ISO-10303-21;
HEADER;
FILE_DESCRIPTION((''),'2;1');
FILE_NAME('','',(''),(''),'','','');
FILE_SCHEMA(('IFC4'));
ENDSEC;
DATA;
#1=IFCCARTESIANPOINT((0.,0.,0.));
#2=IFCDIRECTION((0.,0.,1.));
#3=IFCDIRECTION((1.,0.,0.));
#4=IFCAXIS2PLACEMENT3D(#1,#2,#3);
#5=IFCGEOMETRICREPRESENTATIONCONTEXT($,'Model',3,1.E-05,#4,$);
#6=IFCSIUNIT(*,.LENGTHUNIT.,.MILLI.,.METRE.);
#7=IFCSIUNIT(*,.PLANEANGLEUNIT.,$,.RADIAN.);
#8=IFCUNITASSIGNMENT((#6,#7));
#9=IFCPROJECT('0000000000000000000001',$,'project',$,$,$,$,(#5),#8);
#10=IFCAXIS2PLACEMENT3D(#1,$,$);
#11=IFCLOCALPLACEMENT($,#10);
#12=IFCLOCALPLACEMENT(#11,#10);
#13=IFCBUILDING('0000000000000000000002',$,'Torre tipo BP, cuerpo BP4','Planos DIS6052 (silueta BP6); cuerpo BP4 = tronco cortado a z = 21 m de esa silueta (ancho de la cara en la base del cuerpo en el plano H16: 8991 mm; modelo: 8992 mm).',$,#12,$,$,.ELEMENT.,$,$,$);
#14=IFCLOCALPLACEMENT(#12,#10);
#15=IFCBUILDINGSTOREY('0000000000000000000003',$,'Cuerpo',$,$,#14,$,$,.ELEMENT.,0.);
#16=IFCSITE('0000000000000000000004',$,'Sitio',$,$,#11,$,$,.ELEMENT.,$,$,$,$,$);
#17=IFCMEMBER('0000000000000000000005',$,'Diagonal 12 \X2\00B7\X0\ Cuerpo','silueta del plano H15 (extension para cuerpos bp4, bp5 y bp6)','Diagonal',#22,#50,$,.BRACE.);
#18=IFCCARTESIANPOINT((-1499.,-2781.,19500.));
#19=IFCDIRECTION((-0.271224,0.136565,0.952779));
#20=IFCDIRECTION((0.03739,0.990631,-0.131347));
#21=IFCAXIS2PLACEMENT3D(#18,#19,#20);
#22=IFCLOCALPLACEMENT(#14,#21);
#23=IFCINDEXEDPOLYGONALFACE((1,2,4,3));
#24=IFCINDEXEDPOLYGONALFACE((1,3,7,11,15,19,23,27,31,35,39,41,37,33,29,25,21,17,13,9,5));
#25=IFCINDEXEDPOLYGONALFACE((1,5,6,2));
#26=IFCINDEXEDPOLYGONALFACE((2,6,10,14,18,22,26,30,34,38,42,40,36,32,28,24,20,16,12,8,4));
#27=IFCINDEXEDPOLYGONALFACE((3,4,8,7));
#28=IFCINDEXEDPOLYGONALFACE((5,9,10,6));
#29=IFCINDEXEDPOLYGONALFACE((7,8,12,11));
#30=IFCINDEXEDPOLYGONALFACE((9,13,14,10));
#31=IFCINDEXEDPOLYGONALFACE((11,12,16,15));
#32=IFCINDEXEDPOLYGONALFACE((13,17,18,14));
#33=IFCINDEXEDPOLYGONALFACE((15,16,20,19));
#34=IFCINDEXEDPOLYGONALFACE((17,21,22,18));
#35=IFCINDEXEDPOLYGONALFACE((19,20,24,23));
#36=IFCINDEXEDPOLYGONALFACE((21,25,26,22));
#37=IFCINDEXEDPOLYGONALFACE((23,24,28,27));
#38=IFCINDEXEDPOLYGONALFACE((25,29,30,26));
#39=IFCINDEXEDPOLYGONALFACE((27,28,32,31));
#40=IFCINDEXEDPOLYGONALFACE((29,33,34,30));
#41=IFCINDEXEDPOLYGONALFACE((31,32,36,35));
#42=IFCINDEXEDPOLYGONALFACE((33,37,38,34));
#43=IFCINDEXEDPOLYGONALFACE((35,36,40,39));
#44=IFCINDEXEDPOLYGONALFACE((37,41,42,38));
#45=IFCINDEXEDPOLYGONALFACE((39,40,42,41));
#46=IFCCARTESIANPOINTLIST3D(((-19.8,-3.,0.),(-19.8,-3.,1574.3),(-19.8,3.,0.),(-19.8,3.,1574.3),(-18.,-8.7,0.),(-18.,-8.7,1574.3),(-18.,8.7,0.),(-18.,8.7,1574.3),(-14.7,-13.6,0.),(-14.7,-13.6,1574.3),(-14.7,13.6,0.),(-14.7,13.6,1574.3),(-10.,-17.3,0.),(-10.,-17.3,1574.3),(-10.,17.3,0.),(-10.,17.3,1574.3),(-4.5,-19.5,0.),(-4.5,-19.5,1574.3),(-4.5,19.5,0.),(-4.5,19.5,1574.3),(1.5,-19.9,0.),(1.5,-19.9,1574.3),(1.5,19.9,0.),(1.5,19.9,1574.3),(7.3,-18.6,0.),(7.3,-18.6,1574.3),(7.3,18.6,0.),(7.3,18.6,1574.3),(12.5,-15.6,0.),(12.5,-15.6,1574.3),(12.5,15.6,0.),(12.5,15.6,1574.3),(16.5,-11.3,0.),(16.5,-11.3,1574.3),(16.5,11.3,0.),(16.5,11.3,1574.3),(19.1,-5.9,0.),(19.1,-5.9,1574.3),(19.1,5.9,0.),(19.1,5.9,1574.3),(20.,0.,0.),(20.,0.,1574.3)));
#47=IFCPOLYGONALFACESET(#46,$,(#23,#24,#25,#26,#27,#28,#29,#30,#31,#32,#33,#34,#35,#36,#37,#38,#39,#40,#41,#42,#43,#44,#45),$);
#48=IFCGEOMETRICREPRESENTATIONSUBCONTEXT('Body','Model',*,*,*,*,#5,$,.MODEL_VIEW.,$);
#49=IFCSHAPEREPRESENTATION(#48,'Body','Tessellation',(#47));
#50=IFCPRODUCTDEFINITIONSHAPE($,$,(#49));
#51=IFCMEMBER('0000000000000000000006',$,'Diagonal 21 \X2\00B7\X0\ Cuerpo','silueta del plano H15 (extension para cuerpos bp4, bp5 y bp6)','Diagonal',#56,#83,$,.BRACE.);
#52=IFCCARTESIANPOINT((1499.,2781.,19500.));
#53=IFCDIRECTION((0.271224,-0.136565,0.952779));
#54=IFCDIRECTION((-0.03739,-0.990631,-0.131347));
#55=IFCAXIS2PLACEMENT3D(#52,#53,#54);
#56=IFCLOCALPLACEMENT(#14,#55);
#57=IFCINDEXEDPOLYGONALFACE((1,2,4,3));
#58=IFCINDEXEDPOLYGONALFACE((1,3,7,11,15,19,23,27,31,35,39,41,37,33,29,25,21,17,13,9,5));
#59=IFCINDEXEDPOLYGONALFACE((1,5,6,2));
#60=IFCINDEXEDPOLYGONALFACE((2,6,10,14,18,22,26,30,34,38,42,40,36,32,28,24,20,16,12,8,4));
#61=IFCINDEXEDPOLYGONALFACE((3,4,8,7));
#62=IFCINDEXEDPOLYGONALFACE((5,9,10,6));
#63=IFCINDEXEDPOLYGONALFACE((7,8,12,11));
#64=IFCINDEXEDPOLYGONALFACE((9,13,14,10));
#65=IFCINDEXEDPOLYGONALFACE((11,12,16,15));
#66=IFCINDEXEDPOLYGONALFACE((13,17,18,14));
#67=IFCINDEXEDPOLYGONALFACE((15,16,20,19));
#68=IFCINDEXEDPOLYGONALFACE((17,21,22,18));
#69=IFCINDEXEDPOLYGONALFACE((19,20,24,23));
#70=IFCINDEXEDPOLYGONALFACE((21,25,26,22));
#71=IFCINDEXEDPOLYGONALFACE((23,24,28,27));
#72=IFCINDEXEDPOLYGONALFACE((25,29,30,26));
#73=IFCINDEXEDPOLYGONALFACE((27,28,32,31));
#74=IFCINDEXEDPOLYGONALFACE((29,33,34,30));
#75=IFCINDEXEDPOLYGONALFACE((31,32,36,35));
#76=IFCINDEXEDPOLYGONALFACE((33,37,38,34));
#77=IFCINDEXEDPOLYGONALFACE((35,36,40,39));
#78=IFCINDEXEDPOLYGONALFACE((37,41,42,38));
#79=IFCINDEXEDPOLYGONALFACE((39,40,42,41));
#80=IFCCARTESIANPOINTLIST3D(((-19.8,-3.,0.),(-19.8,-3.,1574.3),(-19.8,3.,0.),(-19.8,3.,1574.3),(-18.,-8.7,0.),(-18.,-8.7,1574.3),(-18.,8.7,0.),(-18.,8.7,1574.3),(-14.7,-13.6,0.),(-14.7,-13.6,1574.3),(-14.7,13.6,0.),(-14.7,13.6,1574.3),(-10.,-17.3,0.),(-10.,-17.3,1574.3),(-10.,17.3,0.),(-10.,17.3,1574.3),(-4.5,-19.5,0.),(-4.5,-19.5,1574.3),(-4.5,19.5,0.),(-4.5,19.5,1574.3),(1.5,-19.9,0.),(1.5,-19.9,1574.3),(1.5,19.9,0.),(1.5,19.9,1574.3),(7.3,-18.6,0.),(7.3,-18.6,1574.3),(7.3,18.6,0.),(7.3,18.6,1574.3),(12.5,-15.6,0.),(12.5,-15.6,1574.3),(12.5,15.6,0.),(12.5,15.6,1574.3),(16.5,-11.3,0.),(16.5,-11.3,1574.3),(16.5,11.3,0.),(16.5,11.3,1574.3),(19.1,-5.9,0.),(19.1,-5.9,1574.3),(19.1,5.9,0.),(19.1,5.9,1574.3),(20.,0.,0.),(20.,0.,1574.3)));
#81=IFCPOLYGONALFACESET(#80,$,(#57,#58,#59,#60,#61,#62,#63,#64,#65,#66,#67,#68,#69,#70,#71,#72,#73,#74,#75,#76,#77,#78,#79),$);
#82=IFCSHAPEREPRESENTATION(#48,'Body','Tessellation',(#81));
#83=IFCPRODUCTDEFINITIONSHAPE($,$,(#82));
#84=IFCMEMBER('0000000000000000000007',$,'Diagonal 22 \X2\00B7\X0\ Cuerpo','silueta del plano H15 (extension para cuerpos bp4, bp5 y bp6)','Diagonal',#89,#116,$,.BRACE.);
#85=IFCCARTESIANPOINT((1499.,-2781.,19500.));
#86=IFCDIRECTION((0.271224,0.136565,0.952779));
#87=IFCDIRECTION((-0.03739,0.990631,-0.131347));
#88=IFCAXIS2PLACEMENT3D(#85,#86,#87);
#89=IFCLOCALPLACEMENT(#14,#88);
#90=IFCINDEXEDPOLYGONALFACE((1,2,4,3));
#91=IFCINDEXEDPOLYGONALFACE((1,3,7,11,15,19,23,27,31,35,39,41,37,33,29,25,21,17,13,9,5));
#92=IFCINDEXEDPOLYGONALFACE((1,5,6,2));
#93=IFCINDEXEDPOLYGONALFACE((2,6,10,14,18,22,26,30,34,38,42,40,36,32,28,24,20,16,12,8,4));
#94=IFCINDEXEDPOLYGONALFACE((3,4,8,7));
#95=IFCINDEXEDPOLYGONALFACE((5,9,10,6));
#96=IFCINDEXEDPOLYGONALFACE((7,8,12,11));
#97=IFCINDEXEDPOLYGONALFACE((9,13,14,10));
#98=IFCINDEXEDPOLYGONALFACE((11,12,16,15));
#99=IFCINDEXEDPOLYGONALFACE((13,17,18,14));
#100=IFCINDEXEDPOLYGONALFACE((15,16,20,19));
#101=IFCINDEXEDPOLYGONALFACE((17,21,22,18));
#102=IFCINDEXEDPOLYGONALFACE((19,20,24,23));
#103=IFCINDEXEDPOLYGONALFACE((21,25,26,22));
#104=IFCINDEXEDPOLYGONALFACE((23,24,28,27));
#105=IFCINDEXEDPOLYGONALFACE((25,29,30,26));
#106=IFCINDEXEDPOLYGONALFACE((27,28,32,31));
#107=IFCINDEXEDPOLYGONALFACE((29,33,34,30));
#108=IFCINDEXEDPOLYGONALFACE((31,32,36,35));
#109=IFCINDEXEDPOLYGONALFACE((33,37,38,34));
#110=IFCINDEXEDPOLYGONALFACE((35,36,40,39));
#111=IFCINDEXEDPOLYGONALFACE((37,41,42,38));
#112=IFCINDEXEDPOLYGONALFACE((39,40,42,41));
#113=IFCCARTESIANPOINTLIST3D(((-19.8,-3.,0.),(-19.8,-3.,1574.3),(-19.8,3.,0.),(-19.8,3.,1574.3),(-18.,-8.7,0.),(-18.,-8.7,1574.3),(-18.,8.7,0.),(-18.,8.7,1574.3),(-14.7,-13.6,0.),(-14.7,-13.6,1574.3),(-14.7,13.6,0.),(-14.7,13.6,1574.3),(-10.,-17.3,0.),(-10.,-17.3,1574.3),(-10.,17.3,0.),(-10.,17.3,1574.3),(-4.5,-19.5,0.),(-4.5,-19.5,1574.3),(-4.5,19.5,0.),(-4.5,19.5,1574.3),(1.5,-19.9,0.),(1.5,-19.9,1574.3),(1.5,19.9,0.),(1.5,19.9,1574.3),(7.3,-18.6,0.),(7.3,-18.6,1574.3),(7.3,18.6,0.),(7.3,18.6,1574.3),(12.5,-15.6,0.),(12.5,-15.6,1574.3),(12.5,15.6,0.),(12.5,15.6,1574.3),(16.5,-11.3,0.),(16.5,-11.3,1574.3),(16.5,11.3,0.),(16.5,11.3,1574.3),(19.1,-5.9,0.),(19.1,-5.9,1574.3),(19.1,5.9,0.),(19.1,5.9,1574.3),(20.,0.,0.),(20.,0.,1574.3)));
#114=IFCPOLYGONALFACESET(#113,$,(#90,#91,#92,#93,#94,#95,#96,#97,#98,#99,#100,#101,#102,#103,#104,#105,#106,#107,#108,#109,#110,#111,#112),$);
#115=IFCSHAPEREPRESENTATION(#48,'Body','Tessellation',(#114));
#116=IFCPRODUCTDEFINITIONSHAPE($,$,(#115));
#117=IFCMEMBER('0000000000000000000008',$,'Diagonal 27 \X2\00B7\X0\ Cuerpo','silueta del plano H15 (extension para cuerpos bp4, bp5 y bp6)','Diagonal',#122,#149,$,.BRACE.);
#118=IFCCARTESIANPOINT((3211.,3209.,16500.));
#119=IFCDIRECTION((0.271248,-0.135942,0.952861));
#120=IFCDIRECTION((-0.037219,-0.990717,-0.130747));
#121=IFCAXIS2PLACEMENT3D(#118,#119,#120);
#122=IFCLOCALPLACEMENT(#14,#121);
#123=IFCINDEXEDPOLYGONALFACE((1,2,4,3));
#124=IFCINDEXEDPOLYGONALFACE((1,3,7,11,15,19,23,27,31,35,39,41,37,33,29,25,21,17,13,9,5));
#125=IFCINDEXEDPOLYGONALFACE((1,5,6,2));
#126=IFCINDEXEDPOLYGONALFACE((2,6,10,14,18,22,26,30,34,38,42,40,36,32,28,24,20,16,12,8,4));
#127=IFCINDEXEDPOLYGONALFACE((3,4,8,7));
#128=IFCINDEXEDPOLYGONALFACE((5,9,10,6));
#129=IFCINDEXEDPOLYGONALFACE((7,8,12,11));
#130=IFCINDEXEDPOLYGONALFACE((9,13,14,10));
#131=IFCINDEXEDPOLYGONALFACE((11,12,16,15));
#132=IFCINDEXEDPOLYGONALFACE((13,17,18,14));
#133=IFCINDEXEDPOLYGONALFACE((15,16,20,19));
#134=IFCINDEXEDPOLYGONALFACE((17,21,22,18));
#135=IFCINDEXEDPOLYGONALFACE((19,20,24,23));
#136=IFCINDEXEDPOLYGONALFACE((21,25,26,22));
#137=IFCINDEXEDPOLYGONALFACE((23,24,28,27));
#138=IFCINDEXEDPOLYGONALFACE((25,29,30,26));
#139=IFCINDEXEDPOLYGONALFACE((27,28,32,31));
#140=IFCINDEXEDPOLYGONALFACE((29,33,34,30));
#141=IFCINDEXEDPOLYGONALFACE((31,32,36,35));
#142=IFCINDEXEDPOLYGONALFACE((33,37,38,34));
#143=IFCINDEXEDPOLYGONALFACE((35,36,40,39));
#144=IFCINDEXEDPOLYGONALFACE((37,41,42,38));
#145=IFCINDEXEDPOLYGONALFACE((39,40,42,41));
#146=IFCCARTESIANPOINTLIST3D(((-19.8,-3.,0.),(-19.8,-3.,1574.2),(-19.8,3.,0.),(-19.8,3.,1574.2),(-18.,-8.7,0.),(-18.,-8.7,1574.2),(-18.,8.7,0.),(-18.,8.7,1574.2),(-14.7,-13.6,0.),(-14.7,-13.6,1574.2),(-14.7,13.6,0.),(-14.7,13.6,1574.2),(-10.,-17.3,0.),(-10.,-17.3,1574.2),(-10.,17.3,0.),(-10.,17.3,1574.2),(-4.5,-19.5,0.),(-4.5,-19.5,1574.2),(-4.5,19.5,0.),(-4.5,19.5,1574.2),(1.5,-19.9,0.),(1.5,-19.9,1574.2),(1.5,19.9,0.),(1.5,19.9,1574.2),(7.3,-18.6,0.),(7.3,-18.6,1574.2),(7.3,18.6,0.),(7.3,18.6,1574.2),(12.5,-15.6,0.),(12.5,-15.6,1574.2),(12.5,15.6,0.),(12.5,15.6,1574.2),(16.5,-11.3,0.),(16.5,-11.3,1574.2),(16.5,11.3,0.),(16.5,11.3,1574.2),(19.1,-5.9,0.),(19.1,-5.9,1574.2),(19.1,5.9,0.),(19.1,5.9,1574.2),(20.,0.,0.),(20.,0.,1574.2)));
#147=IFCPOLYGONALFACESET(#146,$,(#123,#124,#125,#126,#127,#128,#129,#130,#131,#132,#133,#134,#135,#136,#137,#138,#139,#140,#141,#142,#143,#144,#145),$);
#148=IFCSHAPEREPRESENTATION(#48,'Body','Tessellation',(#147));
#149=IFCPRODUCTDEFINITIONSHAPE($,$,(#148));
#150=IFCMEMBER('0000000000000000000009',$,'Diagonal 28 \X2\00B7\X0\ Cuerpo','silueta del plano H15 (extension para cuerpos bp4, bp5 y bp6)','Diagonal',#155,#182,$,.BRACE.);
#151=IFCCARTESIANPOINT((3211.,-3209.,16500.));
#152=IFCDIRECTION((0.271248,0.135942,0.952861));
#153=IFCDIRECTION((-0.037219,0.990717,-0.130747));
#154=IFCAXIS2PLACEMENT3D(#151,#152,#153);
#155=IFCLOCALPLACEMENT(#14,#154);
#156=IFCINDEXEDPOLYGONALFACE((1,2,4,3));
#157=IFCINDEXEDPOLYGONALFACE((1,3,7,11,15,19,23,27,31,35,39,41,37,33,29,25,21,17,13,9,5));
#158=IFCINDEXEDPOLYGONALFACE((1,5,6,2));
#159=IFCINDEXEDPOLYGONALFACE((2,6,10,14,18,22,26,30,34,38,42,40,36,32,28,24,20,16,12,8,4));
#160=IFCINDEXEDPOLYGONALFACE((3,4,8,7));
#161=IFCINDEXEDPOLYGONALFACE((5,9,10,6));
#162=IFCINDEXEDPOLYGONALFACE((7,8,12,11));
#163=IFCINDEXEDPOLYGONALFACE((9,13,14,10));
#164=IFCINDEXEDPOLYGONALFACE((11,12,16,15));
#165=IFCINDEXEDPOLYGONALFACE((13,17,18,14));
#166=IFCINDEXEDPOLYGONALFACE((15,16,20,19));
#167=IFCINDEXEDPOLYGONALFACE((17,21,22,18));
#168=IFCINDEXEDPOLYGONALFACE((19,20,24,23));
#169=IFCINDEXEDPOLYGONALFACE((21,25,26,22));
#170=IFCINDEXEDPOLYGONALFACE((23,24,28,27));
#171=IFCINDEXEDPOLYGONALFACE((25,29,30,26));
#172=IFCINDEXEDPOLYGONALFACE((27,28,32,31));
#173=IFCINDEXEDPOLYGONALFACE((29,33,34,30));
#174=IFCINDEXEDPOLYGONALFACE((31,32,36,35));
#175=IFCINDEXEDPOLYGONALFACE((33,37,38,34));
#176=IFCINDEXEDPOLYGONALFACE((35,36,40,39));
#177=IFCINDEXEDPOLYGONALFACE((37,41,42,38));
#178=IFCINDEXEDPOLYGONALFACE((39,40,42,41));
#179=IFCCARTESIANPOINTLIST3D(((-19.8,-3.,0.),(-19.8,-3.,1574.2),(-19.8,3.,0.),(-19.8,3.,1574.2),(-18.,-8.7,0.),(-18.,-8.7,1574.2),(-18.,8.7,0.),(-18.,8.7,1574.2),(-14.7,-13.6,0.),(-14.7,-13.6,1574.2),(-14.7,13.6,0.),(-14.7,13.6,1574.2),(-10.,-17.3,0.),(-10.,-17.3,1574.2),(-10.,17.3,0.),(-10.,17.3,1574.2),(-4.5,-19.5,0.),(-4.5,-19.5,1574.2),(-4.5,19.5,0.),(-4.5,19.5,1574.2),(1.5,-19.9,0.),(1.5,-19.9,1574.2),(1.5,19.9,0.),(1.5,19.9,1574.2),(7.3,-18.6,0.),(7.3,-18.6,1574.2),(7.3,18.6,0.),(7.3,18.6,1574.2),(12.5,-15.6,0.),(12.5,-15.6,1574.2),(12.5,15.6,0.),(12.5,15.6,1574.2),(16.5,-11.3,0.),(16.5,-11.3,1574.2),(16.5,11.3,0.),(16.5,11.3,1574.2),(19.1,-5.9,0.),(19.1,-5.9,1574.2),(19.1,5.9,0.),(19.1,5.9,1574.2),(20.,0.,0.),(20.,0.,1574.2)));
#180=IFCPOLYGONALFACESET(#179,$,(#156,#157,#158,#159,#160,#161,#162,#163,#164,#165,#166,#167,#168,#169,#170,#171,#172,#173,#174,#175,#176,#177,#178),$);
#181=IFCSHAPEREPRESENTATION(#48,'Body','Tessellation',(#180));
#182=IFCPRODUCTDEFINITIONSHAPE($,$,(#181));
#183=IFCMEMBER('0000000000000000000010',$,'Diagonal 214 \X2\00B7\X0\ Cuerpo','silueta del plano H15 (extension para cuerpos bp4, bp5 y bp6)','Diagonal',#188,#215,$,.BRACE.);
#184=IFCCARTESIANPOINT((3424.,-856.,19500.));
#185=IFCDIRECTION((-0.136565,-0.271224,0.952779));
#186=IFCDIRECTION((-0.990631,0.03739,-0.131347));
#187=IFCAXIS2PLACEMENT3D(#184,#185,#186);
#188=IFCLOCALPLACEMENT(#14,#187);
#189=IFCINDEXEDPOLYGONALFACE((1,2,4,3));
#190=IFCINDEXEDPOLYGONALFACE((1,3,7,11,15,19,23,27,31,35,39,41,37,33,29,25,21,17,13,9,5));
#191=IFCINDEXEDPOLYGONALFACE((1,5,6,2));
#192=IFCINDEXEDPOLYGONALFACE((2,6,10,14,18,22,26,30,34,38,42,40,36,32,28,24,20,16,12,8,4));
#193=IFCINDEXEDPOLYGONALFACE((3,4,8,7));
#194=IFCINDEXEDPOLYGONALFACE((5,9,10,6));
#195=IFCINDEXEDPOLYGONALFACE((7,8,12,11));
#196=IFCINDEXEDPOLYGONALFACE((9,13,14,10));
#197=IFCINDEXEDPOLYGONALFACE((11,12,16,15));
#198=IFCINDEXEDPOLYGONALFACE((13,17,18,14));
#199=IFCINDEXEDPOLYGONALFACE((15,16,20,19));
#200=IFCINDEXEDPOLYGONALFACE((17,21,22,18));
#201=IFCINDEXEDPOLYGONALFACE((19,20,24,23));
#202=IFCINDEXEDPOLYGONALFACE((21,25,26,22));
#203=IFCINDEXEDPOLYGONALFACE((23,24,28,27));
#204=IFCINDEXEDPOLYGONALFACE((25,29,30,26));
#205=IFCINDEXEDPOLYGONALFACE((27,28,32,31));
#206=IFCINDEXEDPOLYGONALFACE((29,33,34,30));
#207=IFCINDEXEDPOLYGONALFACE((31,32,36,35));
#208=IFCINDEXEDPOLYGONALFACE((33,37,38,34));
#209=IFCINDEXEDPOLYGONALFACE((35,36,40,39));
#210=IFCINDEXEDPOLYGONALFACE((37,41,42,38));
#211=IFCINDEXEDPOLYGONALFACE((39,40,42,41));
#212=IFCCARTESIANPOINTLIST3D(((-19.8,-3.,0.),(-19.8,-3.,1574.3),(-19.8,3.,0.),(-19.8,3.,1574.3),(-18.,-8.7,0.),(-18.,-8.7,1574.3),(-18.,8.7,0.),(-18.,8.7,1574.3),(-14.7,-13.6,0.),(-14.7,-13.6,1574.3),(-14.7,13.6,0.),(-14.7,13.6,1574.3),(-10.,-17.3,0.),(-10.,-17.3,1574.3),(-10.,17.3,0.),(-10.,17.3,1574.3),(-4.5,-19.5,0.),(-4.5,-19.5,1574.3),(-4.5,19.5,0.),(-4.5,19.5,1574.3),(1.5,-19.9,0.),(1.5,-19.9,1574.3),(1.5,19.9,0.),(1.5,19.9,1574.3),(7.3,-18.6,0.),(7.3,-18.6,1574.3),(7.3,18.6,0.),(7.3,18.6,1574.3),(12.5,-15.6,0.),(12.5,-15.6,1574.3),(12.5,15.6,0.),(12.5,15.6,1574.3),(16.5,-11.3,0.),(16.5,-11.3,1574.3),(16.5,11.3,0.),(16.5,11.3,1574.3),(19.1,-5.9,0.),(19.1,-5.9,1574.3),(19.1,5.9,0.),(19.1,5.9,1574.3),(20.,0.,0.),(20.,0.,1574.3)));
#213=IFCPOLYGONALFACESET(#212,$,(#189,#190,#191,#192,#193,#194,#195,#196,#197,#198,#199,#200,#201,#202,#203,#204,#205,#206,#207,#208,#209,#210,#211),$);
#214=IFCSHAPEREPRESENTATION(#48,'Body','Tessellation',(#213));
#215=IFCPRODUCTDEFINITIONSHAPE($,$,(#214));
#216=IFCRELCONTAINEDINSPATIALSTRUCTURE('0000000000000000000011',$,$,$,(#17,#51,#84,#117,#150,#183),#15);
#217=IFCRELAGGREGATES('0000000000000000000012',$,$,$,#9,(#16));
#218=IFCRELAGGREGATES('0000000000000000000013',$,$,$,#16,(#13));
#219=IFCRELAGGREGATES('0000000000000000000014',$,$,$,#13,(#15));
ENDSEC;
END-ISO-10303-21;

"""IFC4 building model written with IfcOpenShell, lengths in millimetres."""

from ifc_helpers import new_model, si_unit, frame, origin, origin_with_axes, place, context, subcontext, project, spatial, circle, extrude, element, save


model = new_model("IFC4")

# Units and contexts
model_context = context("Model", 3, precision=1e-05, world=origin_with_axes())
body_context = subcontext(model_context, "Body", "Model", "MODEL_VIEW")
ifc_project = project(units=[si_unit("LENGTHUNIT", "METRE", prefix="MILLI"), si_unit("PLANEANGLEUNIT", "RADIAN")], contexts=[model_context])

# Site, building, storey
site_placement = place(None, origin())
site = spatial("IfcSite", under=ifc_project, at=site_placement, Name="Sitio", CompositionType="ELEMENT")
building_placement = place(site_placement, origin())
building = spatial("IfcBuilding", under=site, at=building_placement, Name="Torre tipo BP, cuerpo BP4", Description="Planos DIS6052 (silueta BP6); cuerpo BP4 = tronco cortado a z = 21 m de esa silueta (ancho de la cara en la base del cuerpo en el plano H16: 8991 mm; modelo: 8992 mm).", CompositionType="ELEMENT")
storey_placement = place(building_placement, origin())
storey = spatial("IfcBuildingStorey", under=building, at=storey_placement, Name="Cuerpo", CompositionType="ELEMENT", Elevation=0.0)

# Members
member_1_placement = place(storey_placement, frame((-1499.0, -2781.0, 19500.0), z_axis=(-0.271224, 0.136565, 0.952779), x_axis=(0.03739, 0.990631, -0.131347)))
element("IfcMember", 1, at=member_1_placement, inside=storey, Name="Diagonal 12 · Cuerpo", Description="silueta del plano H15 (extension para cuerpos bp4, bp5 y bp6)", ObjectType="Diagonal", PredefinedType="BRACE", context=body_context, shape_type="SweptSolid", body=[
    extrude(circle(Radius=20.0), None, (0.0, 0.0, 1.0), 1574.3),
])
for number, where, z_axis, x_axis, name in (
    (2, (1499.0, 2781.0, 19500.0), (0.271224, -0.136565, 0.952779), (-0.03739, -0.990631, -0.131347), "Diagonal 21 · Cuerpo"),
    (3, (1499.0, -2781.0, 19500.0), (0.271224, 0.136565, 0.952779), (-0.03739, 0.990631, -0.131347), "Diagonal 22 · Cuerpo"),
):
    element("IfcMember", number, at=place(storey_placement, frame(where, z_axis=z_axis, x_axis=x_axis)), inside=storey, Name=name, Description="silueta del plano H15 (extension para cuerpos bp4, bp5 y bp6)", ObjectType="Diagonal", PredefinedType="BRACE", context=body_context, shape_type="SweptSolid", body=[
        extrude(circle(Radius=20.0), None, (0.0, 0.0, 1.0), 1574.3),
    ])
for number, where, z_axis, x_axis, name in (
    (4, (3211.0, 3209.0, 16500.0), (0.271248, -0.135942, 0.952861), (-0.037219, -0.990717, -0.130747), "Diagonal 27 · Cuerpo"),
    (5, (3211.0, -3209.0, 16500.0), (0.271248, 0.135942, 0.952861), (-0.037219, 0.990717, -0.130747), "Diagonal 28 · Cuerpo"),
):
    element("IfcMember", number, at=place(storey_placement, frame(where, z_axis=z_axis, x_axis=x_axis)), inside=storey, Name=name, Description="silueta del plano H15 (extension para cuerpos bp4, bp5 y bp6)", ObjectType="Diagonal", PredefinedType="BRACE", context=body_context, shape_type="SweptSolid", body=[
        extrude(circle(Radius=20.0), None, (0.0, 0.0, 1.0), 1574.2),
    ])
member_2_placement = place(storey_placement, frame((3424.0, -856.0, 19500.0), z_axis=(-0.136565, -0.271224, 0.952779), x_axis=(-0.990631, 0.03739, -0.131347)))
element("IfcMember", 6, at=member_2_placement, inside=storey, Name="Diagonal 214 · Cuerpo", Description="silueta del plano H15 (extension para cuerpos bp4, bp5 y bp6)", ObjectType="Diagonal", PredefinedType="BRACE", context=body_context, shape_type="SweptSolid", body=[
    extrude(circle(Radius=20.0), None, (0.0, 0.0, 1.0), 1574.3),
])

save(model, "model.ifc")
